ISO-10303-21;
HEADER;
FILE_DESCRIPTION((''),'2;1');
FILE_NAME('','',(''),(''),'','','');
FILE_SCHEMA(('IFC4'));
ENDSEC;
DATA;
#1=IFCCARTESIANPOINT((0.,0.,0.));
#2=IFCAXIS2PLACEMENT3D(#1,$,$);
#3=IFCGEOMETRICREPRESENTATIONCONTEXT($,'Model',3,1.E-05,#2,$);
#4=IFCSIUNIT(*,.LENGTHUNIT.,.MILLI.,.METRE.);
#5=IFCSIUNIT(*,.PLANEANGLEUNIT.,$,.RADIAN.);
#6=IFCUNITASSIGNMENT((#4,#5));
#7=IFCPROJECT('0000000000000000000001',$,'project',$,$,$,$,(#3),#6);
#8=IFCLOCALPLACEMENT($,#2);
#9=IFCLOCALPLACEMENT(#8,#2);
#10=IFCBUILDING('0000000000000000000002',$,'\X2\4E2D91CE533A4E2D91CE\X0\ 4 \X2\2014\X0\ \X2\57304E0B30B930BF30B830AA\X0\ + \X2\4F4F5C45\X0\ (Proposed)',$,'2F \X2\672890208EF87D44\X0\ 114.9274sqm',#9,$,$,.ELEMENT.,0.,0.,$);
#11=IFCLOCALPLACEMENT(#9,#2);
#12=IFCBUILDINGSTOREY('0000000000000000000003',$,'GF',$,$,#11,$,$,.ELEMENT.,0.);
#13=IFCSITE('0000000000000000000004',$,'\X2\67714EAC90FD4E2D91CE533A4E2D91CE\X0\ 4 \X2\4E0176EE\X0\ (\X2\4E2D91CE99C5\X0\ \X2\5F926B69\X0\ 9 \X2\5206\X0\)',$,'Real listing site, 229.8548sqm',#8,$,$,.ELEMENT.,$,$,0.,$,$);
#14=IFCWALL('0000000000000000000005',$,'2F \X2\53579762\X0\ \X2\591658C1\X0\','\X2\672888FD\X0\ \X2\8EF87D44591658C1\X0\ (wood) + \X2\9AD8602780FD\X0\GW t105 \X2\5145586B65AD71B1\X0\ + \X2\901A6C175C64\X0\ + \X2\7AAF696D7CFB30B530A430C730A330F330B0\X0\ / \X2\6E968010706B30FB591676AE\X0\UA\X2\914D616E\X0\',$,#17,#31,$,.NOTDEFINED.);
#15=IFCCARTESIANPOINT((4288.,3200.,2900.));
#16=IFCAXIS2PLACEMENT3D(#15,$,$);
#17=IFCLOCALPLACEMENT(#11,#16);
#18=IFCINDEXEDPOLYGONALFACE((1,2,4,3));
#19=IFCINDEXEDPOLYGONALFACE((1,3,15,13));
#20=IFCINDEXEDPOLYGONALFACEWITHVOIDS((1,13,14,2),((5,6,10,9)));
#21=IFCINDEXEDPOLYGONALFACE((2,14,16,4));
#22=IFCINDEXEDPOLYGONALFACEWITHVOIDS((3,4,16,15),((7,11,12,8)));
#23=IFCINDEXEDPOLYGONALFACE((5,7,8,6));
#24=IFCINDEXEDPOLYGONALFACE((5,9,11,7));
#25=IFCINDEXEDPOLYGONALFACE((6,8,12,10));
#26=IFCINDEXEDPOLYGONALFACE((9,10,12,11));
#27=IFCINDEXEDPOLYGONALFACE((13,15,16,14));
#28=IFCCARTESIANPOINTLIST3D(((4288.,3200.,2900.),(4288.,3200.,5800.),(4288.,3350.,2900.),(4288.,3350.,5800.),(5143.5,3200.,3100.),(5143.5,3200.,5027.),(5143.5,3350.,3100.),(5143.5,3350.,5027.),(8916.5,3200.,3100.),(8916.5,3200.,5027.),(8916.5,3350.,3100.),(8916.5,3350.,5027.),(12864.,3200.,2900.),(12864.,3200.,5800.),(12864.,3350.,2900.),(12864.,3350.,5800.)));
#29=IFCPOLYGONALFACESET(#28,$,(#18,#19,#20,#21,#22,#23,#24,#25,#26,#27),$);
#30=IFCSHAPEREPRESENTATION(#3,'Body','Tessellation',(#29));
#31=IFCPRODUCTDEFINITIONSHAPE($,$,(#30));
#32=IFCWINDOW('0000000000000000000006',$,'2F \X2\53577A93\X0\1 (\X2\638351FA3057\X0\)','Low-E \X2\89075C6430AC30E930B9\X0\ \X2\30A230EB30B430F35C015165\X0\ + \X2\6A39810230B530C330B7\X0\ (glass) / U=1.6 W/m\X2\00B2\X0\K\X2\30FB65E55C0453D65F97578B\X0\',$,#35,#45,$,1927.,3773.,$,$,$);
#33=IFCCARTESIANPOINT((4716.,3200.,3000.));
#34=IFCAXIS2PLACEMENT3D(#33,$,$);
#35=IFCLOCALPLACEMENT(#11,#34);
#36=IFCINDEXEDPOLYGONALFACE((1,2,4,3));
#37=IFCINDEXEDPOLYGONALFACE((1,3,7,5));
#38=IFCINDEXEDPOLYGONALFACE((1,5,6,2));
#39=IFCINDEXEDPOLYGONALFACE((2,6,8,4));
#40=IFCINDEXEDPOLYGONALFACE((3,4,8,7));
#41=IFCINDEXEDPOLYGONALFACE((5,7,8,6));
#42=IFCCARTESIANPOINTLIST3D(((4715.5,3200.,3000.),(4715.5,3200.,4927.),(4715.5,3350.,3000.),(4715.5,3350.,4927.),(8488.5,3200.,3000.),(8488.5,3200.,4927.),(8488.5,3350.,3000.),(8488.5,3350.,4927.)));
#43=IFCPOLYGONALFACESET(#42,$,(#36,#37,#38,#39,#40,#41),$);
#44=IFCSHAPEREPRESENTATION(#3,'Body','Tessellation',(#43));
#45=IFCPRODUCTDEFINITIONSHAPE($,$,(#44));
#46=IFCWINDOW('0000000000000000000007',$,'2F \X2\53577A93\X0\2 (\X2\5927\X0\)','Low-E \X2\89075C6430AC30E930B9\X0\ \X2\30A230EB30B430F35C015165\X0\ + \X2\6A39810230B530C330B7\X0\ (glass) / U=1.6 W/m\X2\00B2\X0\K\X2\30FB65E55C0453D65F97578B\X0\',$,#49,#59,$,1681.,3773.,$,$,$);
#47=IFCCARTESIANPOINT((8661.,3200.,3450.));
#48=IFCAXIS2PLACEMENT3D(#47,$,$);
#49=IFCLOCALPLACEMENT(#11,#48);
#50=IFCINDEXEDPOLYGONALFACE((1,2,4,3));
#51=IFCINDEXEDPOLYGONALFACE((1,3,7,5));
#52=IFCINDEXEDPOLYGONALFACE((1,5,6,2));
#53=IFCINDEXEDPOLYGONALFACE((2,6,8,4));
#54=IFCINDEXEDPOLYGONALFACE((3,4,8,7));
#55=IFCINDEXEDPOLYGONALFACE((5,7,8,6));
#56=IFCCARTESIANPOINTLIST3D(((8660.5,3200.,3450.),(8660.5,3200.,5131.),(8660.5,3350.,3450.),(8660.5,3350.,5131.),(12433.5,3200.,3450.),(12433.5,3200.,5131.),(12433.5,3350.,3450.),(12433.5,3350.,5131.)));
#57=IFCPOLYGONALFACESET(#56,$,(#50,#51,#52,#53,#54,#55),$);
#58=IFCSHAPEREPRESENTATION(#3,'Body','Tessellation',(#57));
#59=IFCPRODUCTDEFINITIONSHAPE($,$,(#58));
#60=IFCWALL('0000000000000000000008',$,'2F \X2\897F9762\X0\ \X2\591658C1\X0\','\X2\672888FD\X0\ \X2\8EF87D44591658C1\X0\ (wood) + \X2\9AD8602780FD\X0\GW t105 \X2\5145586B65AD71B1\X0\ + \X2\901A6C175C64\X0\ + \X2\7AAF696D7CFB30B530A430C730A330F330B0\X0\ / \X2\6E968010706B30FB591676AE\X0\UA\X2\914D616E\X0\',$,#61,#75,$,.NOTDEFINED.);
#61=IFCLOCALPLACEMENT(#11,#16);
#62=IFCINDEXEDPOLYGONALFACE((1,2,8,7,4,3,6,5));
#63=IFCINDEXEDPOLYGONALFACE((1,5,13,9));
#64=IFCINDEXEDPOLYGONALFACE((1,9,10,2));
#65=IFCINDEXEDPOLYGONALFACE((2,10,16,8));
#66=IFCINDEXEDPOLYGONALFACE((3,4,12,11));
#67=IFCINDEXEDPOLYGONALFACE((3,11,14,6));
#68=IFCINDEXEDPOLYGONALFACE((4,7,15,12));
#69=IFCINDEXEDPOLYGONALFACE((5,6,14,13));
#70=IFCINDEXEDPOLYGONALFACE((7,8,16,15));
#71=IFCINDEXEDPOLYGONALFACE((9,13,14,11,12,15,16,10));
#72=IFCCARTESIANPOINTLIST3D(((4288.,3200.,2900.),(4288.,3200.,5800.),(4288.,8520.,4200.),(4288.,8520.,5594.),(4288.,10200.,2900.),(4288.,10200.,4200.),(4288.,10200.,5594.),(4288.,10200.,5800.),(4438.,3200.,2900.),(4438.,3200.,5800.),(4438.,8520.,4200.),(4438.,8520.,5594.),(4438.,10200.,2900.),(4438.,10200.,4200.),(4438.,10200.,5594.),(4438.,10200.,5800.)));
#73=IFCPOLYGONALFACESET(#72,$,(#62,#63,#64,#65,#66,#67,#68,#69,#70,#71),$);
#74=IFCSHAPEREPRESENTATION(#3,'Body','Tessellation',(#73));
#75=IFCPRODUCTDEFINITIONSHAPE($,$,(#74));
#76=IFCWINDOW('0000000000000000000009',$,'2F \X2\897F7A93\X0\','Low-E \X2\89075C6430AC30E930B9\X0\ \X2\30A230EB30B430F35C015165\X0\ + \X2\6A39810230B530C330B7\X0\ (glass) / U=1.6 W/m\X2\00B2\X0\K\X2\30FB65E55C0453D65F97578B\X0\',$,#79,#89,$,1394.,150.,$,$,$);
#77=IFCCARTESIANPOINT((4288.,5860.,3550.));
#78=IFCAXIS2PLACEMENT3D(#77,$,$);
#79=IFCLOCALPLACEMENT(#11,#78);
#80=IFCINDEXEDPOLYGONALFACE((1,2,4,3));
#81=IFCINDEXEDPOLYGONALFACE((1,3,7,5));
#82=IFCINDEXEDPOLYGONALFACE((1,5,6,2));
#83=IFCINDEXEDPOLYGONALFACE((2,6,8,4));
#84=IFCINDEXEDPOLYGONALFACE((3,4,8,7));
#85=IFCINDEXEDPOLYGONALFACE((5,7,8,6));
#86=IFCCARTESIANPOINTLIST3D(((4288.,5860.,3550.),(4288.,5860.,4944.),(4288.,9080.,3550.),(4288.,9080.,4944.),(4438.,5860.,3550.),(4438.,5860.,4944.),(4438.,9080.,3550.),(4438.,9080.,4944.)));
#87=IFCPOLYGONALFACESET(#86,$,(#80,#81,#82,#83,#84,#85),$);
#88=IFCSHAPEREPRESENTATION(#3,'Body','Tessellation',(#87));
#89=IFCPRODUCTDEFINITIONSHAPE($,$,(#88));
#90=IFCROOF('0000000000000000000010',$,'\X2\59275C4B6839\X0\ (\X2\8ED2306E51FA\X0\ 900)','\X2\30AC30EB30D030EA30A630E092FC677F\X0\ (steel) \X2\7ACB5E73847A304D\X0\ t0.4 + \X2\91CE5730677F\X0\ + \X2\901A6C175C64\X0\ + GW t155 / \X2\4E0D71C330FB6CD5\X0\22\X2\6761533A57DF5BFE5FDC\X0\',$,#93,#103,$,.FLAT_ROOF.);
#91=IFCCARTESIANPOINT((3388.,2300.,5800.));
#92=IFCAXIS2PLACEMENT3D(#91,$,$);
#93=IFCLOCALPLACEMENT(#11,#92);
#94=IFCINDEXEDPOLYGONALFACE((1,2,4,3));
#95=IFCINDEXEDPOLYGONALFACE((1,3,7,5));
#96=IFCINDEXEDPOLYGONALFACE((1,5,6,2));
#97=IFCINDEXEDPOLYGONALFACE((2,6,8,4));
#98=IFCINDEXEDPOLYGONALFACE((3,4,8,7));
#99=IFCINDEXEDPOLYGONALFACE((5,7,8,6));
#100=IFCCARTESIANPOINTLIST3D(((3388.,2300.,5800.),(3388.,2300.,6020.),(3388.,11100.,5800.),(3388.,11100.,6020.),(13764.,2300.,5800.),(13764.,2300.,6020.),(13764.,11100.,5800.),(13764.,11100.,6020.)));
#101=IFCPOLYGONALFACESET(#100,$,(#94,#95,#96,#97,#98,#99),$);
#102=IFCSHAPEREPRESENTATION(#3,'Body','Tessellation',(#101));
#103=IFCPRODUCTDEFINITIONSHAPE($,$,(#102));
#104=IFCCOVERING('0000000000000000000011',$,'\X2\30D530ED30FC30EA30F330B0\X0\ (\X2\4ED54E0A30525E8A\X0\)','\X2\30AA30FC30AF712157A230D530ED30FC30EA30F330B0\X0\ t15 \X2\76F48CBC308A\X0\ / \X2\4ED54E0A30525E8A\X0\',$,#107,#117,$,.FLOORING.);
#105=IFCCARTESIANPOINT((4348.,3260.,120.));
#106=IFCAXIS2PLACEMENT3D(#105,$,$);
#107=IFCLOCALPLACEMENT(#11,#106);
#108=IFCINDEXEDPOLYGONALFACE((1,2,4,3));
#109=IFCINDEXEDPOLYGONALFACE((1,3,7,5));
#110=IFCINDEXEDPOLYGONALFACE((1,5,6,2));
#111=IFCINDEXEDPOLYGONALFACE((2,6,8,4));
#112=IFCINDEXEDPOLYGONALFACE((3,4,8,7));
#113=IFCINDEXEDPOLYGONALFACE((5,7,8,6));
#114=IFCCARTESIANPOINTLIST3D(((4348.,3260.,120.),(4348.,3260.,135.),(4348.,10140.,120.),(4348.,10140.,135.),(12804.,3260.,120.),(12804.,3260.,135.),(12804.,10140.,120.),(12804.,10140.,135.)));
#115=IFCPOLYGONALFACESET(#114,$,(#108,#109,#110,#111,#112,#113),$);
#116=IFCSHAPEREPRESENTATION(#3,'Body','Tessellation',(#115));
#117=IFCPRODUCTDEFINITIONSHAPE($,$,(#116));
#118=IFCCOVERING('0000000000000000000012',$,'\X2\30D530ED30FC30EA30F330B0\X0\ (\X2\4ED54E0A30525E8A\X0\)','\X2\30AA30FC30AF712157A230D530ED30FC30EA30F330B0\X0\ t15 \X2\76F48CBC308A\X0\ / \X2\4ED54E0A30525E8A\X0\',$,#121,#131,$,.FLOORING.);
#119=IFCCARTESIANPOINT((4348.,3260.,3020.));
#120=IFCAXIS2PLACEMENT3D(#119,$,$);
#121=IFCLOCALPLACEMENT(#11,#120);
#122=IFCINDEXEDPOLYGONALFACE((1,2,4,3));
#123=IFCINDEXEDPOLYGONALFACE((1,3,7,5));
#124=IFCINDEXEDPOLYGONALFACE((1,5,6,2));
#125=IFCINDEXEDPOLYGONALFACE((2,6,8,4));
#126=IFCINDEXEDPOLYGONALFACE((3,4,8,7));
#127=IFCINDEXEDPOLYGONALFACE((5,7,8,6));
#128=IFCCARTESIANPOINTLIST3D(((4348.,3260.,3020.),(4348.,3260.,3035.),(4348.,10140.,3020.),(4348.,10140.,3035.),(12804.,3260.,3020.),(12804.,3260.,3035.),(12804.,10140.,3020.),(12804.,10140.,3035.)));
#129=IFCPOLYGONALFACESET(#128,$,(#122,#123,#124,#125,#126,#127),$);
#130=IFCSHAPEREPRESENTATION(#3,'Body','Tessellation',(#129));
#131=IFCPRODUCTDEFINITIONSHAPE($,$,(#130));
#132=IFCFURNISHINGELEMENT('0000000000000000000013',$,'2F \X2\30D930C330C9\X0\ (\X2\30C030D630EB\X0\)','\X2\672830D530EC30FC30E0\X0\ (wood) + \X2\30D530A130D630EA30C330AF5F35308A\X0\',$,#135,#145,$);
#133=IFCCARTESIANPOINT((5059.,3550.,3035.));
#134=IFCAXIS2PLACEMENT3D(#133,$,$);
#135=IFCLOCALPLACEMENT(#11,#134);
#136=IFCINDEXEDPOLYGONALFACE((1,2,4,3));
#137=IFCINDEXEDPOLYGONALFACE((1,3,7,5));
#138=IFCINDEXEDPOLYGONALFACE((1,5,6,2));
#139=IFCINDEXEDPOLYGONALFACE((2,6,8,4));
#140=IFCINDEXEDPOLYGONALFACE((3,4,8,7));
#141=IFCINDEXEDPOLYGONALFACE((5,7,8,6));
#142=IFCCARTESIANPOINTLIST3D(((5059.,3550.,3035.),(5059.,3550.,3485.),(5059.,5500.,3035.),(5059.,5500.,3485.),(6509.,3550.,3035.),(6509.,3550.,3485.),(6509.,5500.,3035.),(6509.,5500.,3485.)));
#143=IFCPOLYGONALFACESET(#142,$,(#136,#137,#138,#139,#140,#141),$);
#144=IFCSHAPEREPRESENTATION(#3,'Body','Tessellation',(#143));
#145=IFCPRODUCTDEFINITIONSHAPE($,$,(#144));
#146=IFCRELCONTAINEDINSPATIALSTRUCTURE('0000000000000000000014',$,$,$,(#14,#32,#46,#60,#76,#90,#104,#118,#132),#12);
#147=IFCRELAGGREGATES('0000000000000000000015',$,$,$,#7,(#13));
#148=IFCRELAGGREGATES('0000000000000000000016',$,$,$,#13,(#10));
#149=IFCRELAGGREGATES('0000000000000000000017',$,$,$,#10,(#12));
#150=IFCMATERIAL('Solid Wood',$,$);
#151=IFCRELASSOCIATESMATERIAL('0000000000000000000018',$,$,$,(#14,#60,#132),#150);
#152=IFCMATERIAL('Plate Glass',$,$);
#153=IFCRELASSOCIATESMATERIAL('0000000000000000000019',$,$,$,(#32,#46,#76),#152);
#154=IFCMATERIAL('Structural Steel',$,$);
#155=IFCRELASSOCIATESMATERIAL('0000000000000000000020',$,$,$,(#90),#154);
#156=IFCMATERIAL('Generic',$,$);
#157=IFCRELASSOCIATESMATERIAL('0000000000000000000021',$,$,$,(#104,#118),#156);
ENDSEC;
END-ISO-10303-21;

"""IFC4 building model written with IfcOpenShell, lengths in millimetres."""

from ifc_helpers import new_model, si_unit, frame, frame_2d, origin, place, context, project, spatial, rectangle, extrude, material, element, fill, save


model = new_model("IFC4")

# Units and contexts
model_context = context("Model", 3, precision=1e-05, world=origin())
ifc_project = project(units=[si_unit("LENGTHUNIT", "METRE", prefix="MILLI"), si_unit("PLANEANGLEUNIT", "RADIAN")], contexts=[model_context])

# Site, building, storey
site_placement = place(None, origin())
site = spatial("IfcSite", under=ifc_project, at=site_placement, Name="東京都中野区中野 4 丁目 (中野駅 徒歩 9 分)", ObjectType="Real listing site, 229.8548sqm", CompositionType="ELEMENT", RefElevation=0.0)
building_placement = place(site_placement, origin())
building = spatial("IfcBuilding", under=site, at=building_placement, Name="中野区中野 4 — 地下スタジオ + 住居 (Proposed)", ObjectType="2F 木造軸組 114.9274sqm", CompositionType="ELEMENT", ElevationOfRefHeight=0.0, ElevationOfTerrain=0.0)
storey_placement = place(building_placement, origin())
storey = spatial("IfcBuildingStorey", under=building, at=storey_placement, Name="GF", CompositionType="ELEMENT", Elevation=0.0)

# Shared definitions
ifc_material_1 = material(Name="Solid Wood")

# Shared definitions
ifc_material_2 = material(Name="Plate Glass")

# Wall, openings, windows
wall_1_placement = place(storey_placement, frame((4288.0, 3200.0, 2900.0)))
wall_1 = element("IfcWall", 1, at=wall_1_placement, inside=storey, material=ifc_material_1, Name="2F 南面 外壁", Description="木製 軸組外壁 (wood) + 高性能GW t105 充填断熱 + 通気層 + 窯業系サイディング / 準耐火・外皮UA配慮", PredefinedType="NOTDEFINED", context=model_context, shape_type="SweptSolid", body=[
    extrude(rectangle(XDim=8576.0, YDim=150.0, at=frame_2d((4288.0, 75.0))), frame((4288.0, 3200.0, 2900.0)), (0.0, 0.0, 1.0), 2900.0),
])
opening_1_placement = place(storey_placement, frame((4716.0, 3200.0, 3000.0)))
opening_1 = element("IfcOpeningElement", 2, at=opening_1_placement, cuts=wall_1, PredefinedType="NOTDEFINED", context=model_context, shape_type="SweptSolid", body=[
    extrude(rectangle(XDim=3773.0, YDim=150.0, at=frame_2d((1886.0, 75.0))), frame((4716.0, 3200.0, 3000.0)), (0.0, 0.0, 1.0), 1927.0),
])
opening_2_placement = place(storey_placement, frame((8661.0, 3200.0, 3450.0)))
opening_2 = element("IfcOpeningElement", 3, at=opening_2_placement, cuts=wall_1, PredefinedType="NOTDEFINED", context=model_context, shape_type="SweptSolid", body=[
    extrude(rectangle(XDim=3773.0, YDim=150.0, at=frame_2d((1886.0, 75.0))), frame((8661.0, 3200.0, 3450.0)), (0.0, 0.0, 1.0), 1681.0),
])
window_1_placement = place(storey_placement, frame((4716.0, 3200.0, 3000.0)))
window_1 = element("IfcWindow", 4, at=window_1_placement, inside=storey, material=ifc_material_2, Name="2F 南窓1 (掃出し)", Description="Low-E 複層ガラス アルゴン封入 + 樹脂サッシ (glass) / U=1.6 W/m²K・日射取得型", OverallHeight=1927.0, OverallWidth=3773.0, context=model_context, shape_type="SweptSolid", body=[
    extrude(rectangle(XDim=3773.0, YDim=150.0, at=frame_2d((1886.0, 75.0))), frame((4716.0, 3200.0, 3000.0)), (0.0, 0.0, 1.0), 1927.0),
])
fill(opening_1, window_1)
window_2_placement = place(storey_placement, frame((8661.0, 3200.0, 3450.0)))
window_2 = element("IfcWindow", 5, at=window_2_placement, inside=storey, material=ifc_material_2, Name="2F 南窓2 (大)", Description="Low-E 複層ガラス アルゴン封入 + 樹脂サッシ (glass) / U=1.6 W/m²K・日射取得型", OverallHeight=1681.0, OverallWidth=3773.0, context=model_context, shape_type="SweptSolid", body=[
    extrude(rectangle(XDim=3773.0, YDim=150.0, at=frame_2d((1886.0, 75.0))), frame((8661.0, 3200.0, 3450.0)), (0.0, 0.0, 1.0), 1681.0),
])
fill(opening_2, window_2)

# Wall, opening, window
wall_2_placement = place(storey_placement, frame((4288.0, 3200.0, 2900.0)))
wall_2 = element("IfcWall", 6, at=wall_2_placement, inside=storey, material=ifc_material_1, Name="2F 西面 外壁", Description="木製 軸組外壁 (wood) + 高性能GW t105 充填断熱 + 通気層 + 窯業系サイディング / 準耐火・外皮UA配慮", PredefinedType="NOTDEFINED", context=model_context, shape_type="SweptSolid", body=[
    extrude(rectangle(XDim=150.0, YDim=7000.0, at=frame_2d((75.0, 3500.0))), frame((4288.0, 3200.0, 2900.0)), (0.0, 0.0, 1.0), 2900.0),
])
opening_3_placement = place(storey_placement, frame((4288.0, 5860.0, 3550.0)))
opening_3 = element("IfcOpeningElement", 7, at=opening_3_placement, cuts=wall_2, PredefinedType="NOTDEFINED", context=model_context, shape_type="SweptSolid", body=[
    extrude(rectangle(XDim=150.0, YDim=3220.0, at=frame_2d((75.0, 1610.0))), frame((4288.0, 5860.0, 3550.0)), (0.0, 0.0, 1.0), 1394.0),
])
window_3_placement = place(storey_placement, frame((4288.0, 5860.0, 3550.0)))
window_3 = element("IfcWindow", 8, at=window_3_placement, inside=storey, material=ifc_material_2, Name="2F 西窓", Description="Low-E 複層ガラス アルゴン封入 + 樹脂サッシ (glass) / U=1.6 W/m²K・日射取得型", OverallHeight=1394.0, OverallWidth=150.0, context=model_context, shape_type="SweptSolid", body=[
    extrude(rectangle(XDim=150.0, YDim=3220.0, at=frame_2d((75.0, 1610.0))), frame((4288.0, 5860.0, 3550.0)), (0.0, 0.0, 1.0), 1394.0),
])
fill(opening_3, window_3)

# Roof
ifc_material_3 = material(Name="Structural Steel")
roof_placement = place(storey_placement, frame((3388.0, 2300.0, 5800.0)))
element("IfcRoof", 9, at=roof_placement, inside=storey, material=ifc_material_3, Name="大屋根 (軒の出 900)", Description="ガルバリウム鋼板 (steel) 立平葺き t0.4 + 野地板 + 通気層 + GW t155 / 不燃・法22条区域対応", PredefinedType="FLAT_ROOF", context=model_context, shape_type="SweptSolid", body=[
    extrude(rectangle(XDim=10376.0, YDim=8800.0, at=frame_2d((5188.0, 4400.0))), frame((3388.0, 2300.0, 5800.0)), (0.0, 0.0, 1.0), 220.0),
])

# Coverings
ifc_material_4 = material(Name="Generic")
covering_1_placement = place(storey_placement, frame((4348.0, 3260.0, 120.0)))
element("IfcCovering", 10, at=covering_1_placement, inside=storey, material=ifc_material_4, Name="フローリング (仕上げ床)", Description="オーク無垢フローリング t15 直貼り / 仕上げ床", PredefinedType="FLOORING", context=model_context, shape_type="SweptSolid", body=[
    extrude(rectangle(XDim=8456.0, YDim=6880.0, at=frame_2d((4228.0, 3440.0))), frame((4348.0, 3260.0, 120.0)), (0.0, 0.0, 1.0), 15.0),
])
covering_2_placement = place(storey_placement, frame((4348.0, 3260.0, 3020.0)))
element("IfcCovering", 11, at=covering_2_placement, inside=storey, material=ifc_material_4, Name="フローリング (仕上げ床)", Description="オーク無垢フローリング t15 直貼り / 仕上げ床", PredefinedType="FLOORING", context=model_context, shape_type="SweptSolid", body=[
    extrude(rectangle(XDim=8456.0, YDim=6880.0, at=frame_2d((4228.0, 3440.0))), frame((4348.0, 3260.0, 3020.0)), (0.0, 0.0, 1.0), 15.0),
])

# Furnishing element
furnishing_placement = place(storey_placement, frame((5059.0, 3550.0, 3035.0)))
element("IfcFurnishingElement", 12, at=furnishing_placement, inside=storey, material=ifc_material_1, Name="2F ベッド (ダブル)", Description="木フレーム (wood) + ファブリック張り", context=model_context, shape_type="SweptSolid", body=[
    extrude(rectangle(XDim=1450.0, YDim=1950.0, at=frame_2d((725.0, 975.0))), frame((5059.0, 3550.0, 3035.0)), (0.0, 0.0, 1.0), 450.0),
])

save(model, "model.ifc")
